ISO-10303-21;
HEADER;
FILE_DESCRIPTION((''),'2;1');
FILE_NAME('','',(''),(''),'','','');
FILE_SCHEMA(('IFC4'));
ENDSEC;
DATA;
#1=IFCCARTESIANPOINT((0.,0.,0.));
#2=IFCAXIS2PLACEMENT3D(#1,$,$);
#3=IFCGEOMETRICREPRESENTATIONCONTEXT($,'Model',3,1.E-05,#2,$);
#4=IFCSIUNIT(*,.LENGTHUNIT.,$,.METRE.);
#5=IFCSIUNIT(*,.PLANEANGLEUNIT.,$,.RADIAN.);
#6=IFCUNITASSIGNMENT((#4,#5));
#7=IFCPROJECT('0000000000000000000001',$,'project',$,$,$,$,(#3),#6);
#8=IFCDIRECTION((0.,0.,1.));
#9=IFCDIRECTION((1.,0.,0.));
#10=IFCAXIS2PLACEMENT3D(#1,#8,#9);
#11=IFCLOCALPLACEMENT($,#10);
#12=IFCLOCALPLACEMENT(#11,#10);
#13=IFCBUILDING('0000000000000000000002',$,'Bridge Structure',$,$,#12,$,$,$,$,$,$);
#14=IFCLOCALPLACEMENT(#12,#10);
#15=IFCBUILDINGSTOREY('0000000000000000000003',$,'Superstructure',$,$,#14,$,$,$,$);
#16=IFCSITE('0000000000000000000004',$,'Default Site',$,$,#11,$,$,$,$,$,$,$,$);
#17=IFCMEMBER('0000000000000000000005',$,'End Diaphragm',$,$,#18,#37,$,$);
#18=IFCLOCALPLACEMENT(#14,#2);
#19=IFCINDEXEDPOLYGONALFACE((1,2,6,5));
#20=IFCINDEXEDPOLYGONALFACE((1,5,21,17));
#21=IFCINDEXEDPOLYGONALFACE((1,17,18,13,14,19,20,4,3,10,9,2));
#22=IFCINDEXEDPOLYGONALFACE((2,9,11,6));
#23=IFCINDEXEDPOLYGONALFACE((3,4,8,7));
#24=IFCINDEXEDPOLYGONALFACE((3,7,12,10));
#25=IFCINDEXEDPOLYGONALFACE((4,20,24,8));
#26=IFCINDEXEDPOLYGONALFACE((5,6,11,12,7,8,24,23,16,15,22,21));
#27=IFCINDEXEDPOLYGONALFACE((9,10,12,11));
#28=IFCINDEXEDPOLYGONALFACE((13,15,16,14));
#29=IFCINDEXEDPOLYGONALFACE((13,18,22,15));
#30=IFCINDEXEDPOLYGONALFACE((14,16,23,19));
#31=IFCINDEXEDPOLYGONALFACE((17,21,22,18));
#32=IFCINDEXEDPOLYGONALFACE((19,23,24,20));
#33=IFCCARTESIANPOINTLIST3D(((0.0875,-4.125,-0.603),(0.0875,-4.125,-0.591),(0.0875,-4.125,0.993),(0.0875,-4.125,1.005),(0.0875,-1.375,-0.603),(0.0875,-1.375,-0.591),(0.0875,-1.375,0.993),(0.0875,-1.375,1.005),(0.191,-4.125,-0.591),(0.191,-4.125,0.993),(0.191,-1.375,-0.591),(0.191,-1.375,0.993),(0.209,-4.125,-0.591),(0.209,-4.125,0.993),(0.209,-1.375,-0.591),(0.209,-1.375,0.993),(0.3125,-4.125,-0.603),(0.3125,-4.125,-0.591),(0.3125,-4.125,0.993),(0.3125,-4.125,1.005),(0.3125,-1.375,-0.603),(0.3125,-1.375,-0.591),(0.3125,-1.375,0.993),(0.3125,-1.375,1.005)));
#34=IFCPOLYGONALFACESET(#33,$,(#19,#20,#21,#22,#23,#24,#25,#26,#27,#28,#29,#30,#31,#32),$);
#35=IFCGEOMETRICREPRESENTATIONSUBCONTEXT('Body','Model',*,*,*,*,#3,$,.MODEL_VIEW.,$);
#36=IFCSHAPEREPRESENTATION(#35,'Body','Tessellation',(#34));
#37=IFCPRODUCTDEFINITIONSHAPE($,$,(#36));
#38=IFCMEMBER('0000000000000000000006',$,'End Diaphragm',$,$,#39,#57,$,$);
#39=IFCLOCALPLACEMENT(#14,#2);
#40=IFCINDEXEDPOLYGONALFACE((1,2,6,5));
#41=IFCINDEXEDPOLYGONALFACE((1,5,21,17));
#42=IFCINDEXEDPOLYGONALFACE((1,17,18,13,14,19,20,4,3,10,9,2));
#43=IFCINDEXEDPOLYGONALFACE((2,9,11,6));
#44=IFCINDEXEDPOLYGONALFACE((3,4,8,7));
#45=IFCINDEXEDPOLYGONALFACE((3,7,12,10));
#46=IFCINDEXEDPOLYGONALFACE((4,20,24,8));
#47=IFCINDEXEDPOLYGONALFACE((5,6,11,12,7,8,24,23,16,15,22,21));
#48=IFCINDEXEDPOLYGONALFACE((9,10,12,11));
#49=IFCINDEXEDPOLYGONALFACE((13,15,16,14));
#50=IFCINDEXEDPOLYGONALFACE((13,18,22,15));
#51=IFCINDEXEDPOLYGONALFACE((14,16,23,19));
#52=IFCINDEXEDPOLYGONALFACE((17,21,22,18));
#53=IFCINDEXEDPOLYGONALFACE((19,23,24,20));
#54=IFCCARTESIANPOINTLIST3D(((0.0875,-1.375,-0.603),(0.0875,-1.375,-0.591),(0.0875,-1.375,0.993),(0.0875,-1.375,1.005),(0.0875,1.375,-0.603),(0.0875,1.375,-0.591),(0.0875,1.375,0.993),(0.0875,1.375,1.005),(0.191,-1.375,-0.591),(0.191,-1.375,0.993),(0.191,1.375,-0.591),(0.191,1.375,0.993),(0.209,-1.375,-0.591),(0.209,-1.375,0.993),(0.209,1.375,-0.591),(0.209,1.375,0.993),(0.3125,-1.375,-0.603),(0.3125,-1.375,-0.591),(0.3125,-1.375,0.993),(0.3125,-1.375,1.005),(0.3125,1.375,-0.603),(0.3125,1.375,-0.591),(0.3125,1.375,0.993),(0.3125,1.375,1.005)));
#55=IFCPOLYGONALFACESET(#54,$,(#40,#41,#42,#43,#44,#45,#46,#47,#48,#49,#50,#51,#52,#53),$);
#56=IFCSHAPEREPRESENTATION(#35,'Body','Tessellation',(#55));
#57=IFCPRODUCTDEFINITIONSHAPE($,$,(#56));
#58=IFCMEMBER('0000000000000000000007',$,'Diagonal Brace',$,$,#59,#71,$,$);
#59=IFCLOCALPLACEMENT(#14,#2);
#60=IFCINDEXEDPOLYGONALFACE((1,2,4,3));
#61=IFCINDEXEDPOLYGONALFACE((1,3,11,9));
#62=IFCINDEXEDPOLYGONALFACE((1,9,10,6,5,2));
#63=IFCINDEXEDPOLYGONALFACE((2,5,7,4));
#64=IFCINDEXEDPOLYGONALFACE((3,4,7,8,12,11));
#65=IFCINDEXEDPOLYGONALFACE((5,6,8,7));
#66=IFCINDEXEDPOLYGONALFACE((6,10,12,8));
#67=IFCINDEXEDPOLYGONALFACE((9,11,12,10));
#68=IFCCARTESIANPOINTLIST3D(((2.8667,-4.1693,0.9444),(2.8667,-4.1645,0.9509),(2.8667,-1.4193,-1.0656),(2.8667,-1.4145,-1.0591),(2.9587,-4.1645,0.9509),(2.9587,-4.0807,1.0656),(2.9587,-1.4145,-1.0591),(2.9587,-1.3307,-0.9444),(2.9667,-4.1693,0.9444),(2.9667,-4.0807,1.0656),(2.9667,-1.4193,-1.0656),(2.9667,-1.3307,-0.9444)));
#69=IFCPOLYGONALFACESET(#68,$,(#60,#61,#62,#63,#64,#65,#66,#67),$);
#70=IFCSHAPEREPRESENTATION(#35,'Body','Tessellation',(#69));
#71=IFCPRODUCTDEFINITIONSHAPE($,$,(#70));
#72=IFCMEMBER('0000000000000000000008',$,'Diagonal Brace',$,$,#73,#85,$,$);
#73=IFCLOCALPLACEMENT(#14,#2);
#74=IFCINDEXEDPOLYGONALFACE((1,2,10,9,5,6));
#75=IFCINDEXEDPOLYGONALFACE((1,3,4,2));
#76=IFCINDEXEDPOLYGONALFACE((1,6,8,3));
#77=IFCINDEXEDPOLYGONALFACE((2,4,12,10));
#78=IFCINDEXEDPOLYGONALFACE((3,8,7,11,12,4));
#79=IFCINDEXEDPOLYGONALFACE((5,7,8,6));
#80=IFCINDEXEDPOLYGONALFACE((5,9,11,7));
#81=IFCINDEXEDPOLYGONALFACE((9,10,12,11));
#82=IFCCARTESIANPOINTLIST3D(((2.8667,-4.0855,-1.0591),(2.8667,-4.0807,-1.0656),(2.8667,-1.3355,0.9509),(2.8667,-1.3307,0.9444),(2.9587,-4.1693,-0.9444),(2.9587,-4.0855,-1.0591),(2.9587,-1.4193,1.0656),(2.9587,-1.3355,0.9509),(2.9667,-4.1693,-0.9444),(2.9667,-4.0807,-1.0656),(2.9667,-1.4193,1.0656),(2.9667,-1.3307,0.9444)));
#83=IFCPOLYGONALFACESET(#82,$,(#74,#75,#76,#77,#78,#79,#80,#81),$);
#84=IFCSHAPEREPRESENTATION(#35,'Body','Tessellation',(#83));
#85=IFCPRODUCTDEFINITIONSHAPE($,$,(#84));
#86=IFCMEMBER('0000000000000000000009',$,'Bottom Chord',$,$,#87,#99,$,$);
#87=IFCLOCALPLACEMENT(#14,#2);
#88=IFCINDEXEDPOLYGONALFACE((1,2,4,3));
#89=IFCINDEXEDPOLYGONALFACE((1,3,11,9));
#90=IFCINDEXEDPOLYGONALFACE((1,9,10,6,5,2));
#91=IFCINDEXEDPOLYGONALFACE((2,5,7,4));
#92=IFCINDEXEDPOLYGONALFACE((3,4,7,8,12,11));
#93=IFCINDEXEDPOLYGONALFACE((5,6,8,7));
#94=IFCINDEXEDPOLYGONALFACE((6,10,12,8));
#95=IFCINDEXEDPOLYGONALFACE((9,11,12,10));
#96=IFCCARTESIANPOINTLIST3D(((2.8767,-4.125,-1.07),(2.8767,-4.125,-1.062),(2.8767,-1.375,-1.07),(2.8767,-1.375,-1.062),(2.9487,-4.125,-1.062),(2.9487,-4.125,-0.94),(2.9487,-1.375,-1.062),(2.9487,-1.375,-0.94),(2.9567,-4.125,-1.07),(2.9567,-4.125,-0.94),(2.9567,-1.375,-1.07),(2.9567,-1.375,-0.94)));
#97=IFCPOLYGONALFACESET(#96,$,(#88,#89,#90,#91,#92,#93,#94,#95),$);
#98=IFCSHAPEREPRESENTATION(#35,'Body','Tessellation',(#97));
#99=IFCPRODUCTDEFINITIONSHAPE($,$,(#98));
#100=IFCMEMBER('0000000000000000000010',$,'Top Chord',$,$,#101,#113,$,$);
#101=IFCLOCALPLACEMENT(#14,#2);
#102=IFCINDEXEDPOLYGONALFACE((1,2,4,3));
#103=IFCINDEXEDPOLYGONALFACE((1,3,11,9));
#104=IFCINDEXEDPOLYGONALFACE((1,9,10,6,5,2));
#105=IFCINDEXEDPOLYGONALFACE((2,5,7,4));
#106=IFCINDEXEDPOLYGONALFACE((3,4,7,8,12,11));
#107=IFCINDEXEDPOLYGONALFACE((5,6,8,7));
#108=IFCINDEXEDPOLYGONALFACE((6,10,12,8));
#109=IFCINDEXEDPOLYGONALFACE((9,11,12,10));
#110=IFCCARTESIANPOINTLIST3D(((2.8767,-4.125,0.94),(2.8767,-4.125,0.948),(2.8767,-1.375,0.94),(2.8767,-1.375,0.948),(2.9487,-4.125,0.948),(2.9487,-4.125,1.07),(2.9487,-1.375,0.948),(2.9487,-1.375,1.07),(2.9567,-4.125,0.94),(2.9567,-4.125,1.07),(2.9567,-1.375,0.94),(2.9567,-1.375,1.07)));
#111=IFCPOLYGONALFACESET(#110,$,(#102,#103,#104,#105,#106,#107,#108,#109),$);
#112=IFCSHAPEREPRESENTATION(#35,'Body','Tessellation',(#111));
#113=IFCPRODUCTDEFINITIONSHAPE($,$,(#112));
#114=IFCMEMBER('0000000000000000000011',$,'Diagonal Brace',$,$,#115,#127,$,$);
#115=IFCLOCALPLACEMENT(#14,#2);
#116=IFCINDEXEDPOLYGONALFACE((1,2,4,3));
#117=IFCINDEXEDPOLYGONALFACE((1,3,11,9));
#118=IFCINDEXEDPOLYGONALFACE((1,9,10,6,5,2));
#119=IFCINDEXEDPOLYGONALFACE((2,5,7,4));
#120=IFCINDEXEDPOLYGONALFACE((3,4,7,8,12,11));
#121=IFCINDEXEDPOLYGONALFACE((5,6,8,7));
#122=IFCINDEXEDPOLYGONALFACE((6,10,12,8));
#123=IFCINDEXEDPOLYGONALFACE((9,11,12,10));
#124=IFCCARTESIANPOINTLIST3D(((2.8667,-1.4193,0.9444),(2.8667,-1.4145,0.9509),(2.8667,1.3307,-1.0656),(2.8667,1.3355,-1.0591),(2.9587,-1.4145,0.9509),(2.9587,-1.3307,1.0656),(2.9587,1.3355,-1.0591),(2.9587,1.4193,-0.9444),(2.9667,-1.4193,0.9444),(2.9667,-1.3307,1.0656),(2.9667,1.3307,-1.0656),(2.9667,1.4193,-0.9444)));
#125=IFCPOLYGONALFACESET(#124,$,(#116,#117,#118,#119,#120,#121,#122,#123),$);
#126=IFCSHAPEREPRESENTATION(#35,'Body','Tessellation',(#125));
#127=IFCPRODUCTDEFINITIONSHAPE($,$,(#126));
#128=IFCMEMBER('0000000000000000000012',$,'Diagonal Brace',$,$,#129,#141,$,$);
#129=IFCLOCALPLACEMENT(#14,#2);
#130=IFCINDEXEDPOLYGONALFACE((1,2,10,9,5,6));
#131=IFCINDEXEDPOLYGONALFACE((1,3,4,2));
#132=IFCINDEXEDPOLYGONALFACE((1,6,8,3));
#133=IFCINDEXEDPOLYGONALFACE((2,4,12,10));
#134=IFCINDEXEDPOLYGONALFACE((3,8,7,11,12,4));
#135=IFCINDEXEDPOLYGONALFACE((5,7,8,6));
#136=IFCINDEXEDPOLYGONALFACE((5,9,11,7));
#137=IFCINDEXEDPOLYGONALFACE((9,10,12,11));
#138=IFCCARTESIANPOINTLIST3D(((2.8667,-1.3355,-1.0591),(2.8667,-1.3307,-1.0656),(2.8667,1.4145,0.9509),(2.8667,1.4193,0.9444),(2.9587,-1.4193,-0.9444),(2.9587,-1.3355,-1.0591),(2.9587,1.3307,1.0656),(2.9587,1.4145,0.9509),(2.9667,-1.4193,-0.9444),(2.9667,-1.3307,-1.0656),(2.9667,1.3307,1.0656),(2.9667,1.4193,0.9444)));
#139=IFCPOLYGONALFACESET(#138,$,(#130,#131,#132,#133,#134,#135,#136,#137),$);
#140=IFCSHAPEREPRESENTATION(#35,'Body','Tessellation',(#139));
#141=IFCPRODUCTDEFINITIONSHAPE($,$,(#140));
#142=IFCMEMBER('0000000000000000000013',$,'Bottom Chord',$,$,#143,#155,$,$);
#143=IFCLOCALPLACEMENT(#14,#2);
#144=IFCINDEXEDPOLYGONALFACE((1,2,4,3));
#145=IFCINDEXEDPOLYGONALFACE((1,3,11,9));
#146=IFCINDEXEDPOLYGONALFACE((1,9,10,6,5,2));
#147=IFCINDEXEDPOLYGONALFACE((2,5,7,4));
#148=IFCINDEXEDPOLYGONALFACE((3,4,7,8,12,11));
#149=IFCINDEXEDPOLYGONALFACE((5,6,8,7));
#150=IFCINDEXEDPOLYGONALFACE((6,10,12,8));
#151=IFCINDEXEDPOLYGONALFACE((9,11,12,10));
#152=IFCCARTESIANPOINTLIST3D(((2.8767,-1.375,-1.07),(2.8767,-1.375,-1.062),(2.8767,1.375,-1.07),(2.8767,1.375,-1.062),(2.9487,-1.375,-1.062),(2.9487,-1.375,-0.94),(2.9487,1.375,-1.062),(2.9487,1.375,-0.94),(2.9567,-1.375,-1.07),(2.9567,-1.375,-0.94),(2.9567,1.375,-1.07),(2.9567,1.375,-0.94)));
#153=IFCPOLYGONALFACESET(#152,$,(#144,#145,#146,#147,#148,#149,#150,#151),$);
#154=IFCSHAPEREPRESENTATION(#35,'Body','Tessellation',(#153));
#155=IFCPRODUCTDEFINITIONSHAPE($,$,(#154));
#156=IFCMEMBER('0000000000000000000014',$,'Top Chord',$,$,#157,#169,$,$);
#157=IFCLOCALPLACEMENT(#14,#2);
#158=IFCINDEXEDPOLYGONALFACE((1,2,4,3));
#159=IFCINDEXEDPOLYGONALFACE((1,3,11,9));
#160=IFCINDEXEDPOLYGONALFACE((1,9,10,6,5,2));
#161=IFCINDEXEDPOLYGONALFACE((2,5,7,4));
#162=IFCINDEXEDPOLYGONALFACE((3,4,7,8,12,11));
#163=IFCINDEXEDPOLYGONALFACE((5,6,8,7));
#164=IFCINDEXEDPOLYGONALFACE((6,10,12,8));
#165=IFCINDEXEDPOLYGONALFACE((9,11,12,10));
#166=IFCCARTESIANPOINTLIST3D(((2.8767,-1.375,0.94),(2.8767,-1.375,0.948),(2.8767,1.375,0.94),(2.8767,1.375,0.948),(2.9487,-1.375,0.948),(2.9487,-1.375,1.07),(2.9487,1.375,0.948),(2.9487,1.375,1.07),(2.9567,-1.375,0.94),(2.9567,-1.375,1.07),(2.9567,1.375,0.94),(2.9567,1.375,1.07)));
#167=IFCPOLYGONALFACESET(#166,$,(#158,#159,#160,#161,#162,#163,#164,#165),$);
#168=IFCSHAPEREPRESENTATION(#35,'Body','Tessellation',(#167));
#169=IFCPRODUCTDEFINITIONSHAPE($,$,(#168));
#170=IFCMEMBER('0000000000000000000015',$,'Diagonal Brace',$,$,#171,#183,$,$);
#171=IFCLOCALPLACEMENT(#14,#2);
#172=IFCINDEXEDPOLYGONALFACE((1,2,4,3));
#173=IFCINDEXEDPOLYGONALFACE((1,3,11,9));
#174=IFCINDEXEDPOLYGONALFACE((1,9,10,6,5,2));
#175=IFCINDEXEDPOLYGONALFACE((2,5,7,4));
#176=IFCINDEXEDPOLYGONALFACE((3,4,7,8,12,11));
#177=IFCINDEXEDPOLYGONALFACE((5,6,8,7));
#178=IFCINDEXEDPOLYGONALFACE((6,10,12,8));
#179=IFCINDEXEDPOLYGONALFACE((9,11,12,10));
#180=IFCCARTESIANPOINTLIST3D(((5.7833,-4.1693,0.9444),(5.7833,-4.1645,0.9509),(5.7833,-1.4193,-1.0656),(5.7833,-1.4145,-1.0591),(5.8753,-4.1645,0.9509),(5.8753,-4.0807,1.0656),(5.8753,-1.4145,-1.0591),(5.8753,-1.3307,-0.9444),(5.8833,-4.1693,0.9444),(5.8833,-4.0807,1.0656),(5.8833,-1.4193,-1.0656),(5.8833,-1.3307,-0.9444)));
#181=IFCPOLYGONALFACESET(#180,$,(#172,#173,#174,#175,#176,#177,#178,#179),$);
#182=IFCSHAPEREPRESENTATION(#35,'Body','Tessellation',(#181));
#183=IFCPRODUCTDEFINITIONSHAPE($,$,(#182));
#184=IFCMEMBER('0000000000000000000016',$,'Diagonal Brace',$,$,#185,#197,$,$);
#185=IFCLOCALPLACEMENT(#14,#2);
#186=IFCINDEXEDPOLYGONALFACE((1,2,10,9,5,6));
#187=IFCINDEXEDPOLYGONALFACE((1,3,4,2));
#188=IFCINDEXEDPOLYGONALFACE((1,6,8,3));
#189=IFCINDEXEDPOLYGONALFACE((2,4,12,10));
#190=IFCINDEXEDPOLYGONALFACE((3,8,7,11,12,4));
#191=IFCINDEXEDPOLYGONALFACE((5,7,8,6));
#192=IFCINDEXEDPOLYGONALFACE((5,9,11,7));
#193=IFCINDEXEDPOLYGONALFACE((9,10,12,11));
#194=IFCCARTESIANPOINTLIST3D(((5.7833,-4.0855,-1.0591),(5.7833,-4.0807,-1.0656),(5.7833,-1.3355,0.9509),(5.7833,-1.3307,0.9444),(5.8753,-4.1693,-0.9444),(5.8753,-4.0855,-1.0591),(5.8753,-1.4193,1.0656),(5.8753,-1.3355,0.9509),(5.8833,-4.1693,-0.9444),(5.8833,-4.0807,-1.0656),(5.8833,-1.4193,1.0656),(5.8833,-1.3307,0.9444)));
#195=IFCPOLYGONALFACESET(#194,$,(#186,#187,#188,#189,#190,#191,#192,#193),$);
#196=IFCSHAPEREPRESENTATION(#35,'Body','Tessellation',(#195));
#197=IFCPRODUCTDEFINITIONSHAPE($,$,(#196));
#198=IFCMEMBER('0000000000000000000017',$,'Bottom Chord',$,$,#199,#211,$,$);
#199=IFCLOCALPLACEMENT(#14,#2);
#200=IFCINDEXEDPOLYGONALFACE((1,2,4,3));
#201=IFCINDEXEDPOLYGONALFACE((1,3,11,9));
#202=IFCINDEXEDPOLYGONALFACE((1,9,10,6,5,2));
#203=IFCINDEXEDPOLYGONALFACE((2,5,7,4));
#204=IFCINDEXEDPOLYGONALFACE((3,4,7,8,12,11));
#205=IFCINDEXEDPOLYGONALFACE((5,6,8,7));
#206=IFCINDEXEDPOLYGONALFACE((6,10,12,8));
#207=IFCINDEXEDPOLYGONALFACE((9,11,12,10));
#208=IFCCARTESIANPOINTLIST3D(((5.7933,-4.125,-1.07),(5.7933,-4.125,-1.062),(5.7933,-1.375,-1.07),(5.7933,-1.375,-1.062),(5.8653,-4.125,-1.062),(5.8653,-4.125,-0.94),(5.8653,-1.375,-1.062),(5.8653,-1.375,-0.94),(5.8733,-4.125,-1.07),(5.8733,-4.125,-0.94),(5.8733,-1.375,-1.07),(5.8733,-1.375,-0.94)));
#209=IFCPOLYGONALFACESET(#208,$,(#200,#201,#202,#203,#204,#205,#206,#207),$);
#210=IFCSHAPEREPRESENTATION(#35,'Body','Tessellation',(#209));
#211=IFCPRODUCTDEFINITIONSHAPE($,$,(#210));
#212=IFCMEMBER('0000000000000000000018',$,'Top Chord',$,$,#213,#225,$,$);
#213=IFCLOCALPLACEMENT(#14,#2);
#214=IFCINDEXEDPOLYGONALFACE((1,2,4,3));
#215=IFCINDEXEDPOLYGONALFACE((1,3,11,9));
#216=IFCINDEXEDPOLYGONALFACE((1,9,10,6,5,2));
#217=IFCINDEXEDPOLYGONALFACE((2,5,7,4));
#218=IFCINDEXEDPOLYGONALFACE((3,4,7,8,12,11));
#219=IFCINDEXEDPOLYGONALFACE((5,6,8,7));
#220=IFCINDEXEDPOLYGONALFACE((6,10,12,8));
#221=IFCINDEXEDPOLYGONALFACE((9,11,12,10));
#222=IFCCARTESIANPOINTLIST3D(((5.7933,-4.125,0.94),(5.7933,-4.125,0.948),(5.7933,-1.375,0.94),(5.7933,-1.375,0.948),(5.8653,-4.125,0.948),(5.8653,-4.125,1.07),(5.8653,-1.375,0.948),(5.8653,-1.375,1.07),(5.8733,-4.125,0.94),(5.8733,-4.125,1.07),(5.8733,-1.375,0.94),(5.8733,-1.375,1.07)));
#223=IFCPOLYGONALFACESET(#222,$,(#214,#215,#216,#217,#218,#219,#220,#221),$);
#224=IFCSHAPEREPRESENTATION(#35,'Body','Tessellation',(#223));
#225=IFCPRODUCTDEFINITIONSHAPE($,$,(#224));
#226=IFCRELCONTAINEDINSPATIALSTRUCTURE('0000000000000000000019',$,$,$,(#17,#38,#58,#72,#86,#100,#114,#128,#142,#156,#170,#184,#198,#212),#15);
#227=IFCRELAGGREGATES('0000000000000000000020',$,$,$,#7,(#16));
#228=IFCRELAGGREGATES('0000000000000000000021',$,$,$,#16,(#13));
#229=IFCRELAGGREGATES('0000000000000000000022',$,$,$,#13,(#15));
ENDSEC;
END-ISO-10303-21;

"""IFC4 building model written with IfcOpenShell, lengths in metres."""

from ifc_helpers import new_model, si_unit, frame, origin, origin_with_axes, origin_2d_with_axis, place, context, subcontext, project, spatial, i_section, l_section, extrude, element, save


model = new_model("IFC4")

# Units and contexts
model_context = context("Model", 3, precision=1e-05, world=origin())
body_context = subcontext(model_context, "Body", "Model", "MODEL_VIEW")
ifc_project = project(units=[si_unit("LENGTHUNIT", "METRE"), si_unit("PLANEANGLEUNIT", "RADIAN")], contexts=[model_context])

# Site, building, storey
site_placement = place(None, origin_with_axes())
site = spatial("IfcSite", under=ifc_project, at=site_placement, Name="Default Site")
building_placement = place(site_placement, origin_with_axes())
building = spatial("IfcBuilding", under=site, at=building_placement, Name="Bridge Structure")
storey_placement = place(building_placement, origin_with_axes())
storey = spatial("IfcBuildingStorey", under=building, at=storey_placement, Name="Superstructure")

# Members
for number, where, z_axis, x_axis, name in (
    (1, (0.2, -4.125, 0.201), (0.0, 1.0, 0.0), (-1.0, 0.0, 0.0), "End Diaphragm"),
    (2, (0.2, -1.375, 0.201), (0.0, 1.0, 0.0), (-1.0, 0.0, 0.0), "End Diaphragm"),
):
    element("IfcMember", number, at=place(storey_placement, frame(where, z_axis=z_axis, x_axis=x_axis)), inside=storey, Name=name, context=body_context, shape_type="SweptSolid", body=[
        extrude(i_section(OverallWidth=0.225, OverallDepth=1.608, WebThickness=0.018, FlangeThickness=0.012, at=origin_2d_with_axis()), origin_with_axes(), (0.0, 0.0, 1.0), 2.75),
    ])
for number, where, z_axis, x_axis, name in (
    (3, (2.9167, -4.125, 1.005), (0.0, 0.807337, -0.59009), (-1.0, 0.0, 0.0), "Diagonal Brace"),
    (4, (2.9167, -4.125, -1.005), (0.0, 0.807337, 0.59009), (-1.0, 0.0, 0.0), "Diagonal Brace"),
):
    element("IfcMember", number, at=place(storey_placement, frame(where, z_axis=z_axis, x_axis=x_axis)), inside=storey, Name=name, context=body_context, shape_type="SweptSolid", body=[
        extrude(l_section(Depth=0.15, Width=0.1, Thickness=0.008, at=origin_2d_with_axis()), origin_with_axes(), (0.0, 0.0, 1.0), 3.4063),
    ])
for number, where, z_axis, x_axis, name in (
    (5, (2.9167, -4.125, -1.005), (0.0, 1.0, 0.0), (-1.0, 0.0, 0.0), "Bottom Chord"),
    (6, (2.9167, -4.125, 1.005), (0.0, 1.0, 0.0), (-1.0, 0.0, 0.0), "Top Chord"),
):
    element("IfcMember", number, at=place(storey_placement, frame(where, z_axis=z_axis, x_axis=x_axis)), inside=storey, Name=name, context=body_context, shape_type="SweptSolid", body=[
        extrude(l_section(Depth=0.13, Width=0.08, Thickness=0.008, at=origin_2d_with_axis()), origin_with_axes(), (0.0, 0.0, 1.0), 2.75),
    ])
for number, where, z_axis, x_axis, name in (
    (7, (2.9167, -1.375, 1.005), (0.0, 0.807337, -0.59009), (-1.0, 0.0, 0.0), "Diagonal Brace"),
    (8, (2.9167, -1.375, -1.005), (0.0, 0.807337, 0.59009), (-1.0, 0.0, 0.0), "Diagonal Brace"),
):
    element("IfcMember", number, at=place(storey_placement, frame(where, z_axis=z_axis, x_axis=x_axis)), inside=storey, Name=name, context=body_context, shape_type="SweptSolid", body=[
        extrude(l_section(Depth=0.15, Width=0.1, Thickness=0.008, at=origin_2d_with_axis()), origin_with_axes(), (0.0, 0.0, 1.0), 3.4063),
    ])
for number, where, z_axis, x_axis, name in (
    (9, (2.9167, -1.375, -1.005), (0.0, 1.0, 0.0), (-1.0, 0.0, 0.0), "Bottom Chord"),
    (10, (2.9167, -1.375, 1.005), (0.0, 1.0, 0.0), (-1.0, 0.0, 0.0), "Top Chord"),
):
    element("IfcMember", number, at=place(storey_placement, frame(where, z_axis=z_axis, x_axis=x_axis)), inside=storey, Name=name, context=body_context, shape_type="SweptSolid", body=[
        extrude(l_section(Depth=0.13, Width=0.08, Thickness=0.008, at=origin_2d_with_axis()), origin_with_axes(), (0.0, 0.0, 1.0), 2.75),
    ])
for number, where, z_axis, x_axis, name in (
    (11, (5.8333, -4.125, 1.005), (0.0, 0.807337, -0.59009), (-1.0, 0.0, 0.0), "Diagonal Brace"),
    (12, (5.8333, -4.125, -1.005), (0.0, 0.807337, 0.59009), (-1.0, 0.0, 0.0), "Diagonal Brace"),
):
    element("IfcMember", number, at=place(storey_placement, frame(where, z_axis=z_axis, x_axis=x_axis)), inside=storey, Name=name, context=body_context, shape_type="SweptSolid", body=[
        extrude(l_section(Depth=0.15, Width=0.1, Thickness=0.008, at=origin_2d_with_axis()), origin_with_axes(), (0.0, 0.0, 1.0), 3.4063),
    ])
for number, where, z_axis, x_axis, name in (
    (13, (5.8333, -4.125, -1.005), (0.0, 1.0, 0.0), (-1.0, 0.0, 0.0), "Bottom Chord"),
    (14, (5.8333, -4.125, 1.005), (0.0, 1.0, 0.0), (-1.0, 0.0, 0.0), "Top Chord"),
):
    element("IfcMember", number, at=place(storey_placement, frame(where, z_axis=z_axis, x_axis=x_axis)), inside=storey, Name=name, context=body_context, shape_type="SweptSolid", body=[
        extrude(l_section(Depth=0.13, Width=0.08, Thickness=0.008, at=origin_2d_with_axis()), origin_with_axes(), (0.0, 0.0, 1.0), 2.75),
    ])

save(model, "model.ifc")
